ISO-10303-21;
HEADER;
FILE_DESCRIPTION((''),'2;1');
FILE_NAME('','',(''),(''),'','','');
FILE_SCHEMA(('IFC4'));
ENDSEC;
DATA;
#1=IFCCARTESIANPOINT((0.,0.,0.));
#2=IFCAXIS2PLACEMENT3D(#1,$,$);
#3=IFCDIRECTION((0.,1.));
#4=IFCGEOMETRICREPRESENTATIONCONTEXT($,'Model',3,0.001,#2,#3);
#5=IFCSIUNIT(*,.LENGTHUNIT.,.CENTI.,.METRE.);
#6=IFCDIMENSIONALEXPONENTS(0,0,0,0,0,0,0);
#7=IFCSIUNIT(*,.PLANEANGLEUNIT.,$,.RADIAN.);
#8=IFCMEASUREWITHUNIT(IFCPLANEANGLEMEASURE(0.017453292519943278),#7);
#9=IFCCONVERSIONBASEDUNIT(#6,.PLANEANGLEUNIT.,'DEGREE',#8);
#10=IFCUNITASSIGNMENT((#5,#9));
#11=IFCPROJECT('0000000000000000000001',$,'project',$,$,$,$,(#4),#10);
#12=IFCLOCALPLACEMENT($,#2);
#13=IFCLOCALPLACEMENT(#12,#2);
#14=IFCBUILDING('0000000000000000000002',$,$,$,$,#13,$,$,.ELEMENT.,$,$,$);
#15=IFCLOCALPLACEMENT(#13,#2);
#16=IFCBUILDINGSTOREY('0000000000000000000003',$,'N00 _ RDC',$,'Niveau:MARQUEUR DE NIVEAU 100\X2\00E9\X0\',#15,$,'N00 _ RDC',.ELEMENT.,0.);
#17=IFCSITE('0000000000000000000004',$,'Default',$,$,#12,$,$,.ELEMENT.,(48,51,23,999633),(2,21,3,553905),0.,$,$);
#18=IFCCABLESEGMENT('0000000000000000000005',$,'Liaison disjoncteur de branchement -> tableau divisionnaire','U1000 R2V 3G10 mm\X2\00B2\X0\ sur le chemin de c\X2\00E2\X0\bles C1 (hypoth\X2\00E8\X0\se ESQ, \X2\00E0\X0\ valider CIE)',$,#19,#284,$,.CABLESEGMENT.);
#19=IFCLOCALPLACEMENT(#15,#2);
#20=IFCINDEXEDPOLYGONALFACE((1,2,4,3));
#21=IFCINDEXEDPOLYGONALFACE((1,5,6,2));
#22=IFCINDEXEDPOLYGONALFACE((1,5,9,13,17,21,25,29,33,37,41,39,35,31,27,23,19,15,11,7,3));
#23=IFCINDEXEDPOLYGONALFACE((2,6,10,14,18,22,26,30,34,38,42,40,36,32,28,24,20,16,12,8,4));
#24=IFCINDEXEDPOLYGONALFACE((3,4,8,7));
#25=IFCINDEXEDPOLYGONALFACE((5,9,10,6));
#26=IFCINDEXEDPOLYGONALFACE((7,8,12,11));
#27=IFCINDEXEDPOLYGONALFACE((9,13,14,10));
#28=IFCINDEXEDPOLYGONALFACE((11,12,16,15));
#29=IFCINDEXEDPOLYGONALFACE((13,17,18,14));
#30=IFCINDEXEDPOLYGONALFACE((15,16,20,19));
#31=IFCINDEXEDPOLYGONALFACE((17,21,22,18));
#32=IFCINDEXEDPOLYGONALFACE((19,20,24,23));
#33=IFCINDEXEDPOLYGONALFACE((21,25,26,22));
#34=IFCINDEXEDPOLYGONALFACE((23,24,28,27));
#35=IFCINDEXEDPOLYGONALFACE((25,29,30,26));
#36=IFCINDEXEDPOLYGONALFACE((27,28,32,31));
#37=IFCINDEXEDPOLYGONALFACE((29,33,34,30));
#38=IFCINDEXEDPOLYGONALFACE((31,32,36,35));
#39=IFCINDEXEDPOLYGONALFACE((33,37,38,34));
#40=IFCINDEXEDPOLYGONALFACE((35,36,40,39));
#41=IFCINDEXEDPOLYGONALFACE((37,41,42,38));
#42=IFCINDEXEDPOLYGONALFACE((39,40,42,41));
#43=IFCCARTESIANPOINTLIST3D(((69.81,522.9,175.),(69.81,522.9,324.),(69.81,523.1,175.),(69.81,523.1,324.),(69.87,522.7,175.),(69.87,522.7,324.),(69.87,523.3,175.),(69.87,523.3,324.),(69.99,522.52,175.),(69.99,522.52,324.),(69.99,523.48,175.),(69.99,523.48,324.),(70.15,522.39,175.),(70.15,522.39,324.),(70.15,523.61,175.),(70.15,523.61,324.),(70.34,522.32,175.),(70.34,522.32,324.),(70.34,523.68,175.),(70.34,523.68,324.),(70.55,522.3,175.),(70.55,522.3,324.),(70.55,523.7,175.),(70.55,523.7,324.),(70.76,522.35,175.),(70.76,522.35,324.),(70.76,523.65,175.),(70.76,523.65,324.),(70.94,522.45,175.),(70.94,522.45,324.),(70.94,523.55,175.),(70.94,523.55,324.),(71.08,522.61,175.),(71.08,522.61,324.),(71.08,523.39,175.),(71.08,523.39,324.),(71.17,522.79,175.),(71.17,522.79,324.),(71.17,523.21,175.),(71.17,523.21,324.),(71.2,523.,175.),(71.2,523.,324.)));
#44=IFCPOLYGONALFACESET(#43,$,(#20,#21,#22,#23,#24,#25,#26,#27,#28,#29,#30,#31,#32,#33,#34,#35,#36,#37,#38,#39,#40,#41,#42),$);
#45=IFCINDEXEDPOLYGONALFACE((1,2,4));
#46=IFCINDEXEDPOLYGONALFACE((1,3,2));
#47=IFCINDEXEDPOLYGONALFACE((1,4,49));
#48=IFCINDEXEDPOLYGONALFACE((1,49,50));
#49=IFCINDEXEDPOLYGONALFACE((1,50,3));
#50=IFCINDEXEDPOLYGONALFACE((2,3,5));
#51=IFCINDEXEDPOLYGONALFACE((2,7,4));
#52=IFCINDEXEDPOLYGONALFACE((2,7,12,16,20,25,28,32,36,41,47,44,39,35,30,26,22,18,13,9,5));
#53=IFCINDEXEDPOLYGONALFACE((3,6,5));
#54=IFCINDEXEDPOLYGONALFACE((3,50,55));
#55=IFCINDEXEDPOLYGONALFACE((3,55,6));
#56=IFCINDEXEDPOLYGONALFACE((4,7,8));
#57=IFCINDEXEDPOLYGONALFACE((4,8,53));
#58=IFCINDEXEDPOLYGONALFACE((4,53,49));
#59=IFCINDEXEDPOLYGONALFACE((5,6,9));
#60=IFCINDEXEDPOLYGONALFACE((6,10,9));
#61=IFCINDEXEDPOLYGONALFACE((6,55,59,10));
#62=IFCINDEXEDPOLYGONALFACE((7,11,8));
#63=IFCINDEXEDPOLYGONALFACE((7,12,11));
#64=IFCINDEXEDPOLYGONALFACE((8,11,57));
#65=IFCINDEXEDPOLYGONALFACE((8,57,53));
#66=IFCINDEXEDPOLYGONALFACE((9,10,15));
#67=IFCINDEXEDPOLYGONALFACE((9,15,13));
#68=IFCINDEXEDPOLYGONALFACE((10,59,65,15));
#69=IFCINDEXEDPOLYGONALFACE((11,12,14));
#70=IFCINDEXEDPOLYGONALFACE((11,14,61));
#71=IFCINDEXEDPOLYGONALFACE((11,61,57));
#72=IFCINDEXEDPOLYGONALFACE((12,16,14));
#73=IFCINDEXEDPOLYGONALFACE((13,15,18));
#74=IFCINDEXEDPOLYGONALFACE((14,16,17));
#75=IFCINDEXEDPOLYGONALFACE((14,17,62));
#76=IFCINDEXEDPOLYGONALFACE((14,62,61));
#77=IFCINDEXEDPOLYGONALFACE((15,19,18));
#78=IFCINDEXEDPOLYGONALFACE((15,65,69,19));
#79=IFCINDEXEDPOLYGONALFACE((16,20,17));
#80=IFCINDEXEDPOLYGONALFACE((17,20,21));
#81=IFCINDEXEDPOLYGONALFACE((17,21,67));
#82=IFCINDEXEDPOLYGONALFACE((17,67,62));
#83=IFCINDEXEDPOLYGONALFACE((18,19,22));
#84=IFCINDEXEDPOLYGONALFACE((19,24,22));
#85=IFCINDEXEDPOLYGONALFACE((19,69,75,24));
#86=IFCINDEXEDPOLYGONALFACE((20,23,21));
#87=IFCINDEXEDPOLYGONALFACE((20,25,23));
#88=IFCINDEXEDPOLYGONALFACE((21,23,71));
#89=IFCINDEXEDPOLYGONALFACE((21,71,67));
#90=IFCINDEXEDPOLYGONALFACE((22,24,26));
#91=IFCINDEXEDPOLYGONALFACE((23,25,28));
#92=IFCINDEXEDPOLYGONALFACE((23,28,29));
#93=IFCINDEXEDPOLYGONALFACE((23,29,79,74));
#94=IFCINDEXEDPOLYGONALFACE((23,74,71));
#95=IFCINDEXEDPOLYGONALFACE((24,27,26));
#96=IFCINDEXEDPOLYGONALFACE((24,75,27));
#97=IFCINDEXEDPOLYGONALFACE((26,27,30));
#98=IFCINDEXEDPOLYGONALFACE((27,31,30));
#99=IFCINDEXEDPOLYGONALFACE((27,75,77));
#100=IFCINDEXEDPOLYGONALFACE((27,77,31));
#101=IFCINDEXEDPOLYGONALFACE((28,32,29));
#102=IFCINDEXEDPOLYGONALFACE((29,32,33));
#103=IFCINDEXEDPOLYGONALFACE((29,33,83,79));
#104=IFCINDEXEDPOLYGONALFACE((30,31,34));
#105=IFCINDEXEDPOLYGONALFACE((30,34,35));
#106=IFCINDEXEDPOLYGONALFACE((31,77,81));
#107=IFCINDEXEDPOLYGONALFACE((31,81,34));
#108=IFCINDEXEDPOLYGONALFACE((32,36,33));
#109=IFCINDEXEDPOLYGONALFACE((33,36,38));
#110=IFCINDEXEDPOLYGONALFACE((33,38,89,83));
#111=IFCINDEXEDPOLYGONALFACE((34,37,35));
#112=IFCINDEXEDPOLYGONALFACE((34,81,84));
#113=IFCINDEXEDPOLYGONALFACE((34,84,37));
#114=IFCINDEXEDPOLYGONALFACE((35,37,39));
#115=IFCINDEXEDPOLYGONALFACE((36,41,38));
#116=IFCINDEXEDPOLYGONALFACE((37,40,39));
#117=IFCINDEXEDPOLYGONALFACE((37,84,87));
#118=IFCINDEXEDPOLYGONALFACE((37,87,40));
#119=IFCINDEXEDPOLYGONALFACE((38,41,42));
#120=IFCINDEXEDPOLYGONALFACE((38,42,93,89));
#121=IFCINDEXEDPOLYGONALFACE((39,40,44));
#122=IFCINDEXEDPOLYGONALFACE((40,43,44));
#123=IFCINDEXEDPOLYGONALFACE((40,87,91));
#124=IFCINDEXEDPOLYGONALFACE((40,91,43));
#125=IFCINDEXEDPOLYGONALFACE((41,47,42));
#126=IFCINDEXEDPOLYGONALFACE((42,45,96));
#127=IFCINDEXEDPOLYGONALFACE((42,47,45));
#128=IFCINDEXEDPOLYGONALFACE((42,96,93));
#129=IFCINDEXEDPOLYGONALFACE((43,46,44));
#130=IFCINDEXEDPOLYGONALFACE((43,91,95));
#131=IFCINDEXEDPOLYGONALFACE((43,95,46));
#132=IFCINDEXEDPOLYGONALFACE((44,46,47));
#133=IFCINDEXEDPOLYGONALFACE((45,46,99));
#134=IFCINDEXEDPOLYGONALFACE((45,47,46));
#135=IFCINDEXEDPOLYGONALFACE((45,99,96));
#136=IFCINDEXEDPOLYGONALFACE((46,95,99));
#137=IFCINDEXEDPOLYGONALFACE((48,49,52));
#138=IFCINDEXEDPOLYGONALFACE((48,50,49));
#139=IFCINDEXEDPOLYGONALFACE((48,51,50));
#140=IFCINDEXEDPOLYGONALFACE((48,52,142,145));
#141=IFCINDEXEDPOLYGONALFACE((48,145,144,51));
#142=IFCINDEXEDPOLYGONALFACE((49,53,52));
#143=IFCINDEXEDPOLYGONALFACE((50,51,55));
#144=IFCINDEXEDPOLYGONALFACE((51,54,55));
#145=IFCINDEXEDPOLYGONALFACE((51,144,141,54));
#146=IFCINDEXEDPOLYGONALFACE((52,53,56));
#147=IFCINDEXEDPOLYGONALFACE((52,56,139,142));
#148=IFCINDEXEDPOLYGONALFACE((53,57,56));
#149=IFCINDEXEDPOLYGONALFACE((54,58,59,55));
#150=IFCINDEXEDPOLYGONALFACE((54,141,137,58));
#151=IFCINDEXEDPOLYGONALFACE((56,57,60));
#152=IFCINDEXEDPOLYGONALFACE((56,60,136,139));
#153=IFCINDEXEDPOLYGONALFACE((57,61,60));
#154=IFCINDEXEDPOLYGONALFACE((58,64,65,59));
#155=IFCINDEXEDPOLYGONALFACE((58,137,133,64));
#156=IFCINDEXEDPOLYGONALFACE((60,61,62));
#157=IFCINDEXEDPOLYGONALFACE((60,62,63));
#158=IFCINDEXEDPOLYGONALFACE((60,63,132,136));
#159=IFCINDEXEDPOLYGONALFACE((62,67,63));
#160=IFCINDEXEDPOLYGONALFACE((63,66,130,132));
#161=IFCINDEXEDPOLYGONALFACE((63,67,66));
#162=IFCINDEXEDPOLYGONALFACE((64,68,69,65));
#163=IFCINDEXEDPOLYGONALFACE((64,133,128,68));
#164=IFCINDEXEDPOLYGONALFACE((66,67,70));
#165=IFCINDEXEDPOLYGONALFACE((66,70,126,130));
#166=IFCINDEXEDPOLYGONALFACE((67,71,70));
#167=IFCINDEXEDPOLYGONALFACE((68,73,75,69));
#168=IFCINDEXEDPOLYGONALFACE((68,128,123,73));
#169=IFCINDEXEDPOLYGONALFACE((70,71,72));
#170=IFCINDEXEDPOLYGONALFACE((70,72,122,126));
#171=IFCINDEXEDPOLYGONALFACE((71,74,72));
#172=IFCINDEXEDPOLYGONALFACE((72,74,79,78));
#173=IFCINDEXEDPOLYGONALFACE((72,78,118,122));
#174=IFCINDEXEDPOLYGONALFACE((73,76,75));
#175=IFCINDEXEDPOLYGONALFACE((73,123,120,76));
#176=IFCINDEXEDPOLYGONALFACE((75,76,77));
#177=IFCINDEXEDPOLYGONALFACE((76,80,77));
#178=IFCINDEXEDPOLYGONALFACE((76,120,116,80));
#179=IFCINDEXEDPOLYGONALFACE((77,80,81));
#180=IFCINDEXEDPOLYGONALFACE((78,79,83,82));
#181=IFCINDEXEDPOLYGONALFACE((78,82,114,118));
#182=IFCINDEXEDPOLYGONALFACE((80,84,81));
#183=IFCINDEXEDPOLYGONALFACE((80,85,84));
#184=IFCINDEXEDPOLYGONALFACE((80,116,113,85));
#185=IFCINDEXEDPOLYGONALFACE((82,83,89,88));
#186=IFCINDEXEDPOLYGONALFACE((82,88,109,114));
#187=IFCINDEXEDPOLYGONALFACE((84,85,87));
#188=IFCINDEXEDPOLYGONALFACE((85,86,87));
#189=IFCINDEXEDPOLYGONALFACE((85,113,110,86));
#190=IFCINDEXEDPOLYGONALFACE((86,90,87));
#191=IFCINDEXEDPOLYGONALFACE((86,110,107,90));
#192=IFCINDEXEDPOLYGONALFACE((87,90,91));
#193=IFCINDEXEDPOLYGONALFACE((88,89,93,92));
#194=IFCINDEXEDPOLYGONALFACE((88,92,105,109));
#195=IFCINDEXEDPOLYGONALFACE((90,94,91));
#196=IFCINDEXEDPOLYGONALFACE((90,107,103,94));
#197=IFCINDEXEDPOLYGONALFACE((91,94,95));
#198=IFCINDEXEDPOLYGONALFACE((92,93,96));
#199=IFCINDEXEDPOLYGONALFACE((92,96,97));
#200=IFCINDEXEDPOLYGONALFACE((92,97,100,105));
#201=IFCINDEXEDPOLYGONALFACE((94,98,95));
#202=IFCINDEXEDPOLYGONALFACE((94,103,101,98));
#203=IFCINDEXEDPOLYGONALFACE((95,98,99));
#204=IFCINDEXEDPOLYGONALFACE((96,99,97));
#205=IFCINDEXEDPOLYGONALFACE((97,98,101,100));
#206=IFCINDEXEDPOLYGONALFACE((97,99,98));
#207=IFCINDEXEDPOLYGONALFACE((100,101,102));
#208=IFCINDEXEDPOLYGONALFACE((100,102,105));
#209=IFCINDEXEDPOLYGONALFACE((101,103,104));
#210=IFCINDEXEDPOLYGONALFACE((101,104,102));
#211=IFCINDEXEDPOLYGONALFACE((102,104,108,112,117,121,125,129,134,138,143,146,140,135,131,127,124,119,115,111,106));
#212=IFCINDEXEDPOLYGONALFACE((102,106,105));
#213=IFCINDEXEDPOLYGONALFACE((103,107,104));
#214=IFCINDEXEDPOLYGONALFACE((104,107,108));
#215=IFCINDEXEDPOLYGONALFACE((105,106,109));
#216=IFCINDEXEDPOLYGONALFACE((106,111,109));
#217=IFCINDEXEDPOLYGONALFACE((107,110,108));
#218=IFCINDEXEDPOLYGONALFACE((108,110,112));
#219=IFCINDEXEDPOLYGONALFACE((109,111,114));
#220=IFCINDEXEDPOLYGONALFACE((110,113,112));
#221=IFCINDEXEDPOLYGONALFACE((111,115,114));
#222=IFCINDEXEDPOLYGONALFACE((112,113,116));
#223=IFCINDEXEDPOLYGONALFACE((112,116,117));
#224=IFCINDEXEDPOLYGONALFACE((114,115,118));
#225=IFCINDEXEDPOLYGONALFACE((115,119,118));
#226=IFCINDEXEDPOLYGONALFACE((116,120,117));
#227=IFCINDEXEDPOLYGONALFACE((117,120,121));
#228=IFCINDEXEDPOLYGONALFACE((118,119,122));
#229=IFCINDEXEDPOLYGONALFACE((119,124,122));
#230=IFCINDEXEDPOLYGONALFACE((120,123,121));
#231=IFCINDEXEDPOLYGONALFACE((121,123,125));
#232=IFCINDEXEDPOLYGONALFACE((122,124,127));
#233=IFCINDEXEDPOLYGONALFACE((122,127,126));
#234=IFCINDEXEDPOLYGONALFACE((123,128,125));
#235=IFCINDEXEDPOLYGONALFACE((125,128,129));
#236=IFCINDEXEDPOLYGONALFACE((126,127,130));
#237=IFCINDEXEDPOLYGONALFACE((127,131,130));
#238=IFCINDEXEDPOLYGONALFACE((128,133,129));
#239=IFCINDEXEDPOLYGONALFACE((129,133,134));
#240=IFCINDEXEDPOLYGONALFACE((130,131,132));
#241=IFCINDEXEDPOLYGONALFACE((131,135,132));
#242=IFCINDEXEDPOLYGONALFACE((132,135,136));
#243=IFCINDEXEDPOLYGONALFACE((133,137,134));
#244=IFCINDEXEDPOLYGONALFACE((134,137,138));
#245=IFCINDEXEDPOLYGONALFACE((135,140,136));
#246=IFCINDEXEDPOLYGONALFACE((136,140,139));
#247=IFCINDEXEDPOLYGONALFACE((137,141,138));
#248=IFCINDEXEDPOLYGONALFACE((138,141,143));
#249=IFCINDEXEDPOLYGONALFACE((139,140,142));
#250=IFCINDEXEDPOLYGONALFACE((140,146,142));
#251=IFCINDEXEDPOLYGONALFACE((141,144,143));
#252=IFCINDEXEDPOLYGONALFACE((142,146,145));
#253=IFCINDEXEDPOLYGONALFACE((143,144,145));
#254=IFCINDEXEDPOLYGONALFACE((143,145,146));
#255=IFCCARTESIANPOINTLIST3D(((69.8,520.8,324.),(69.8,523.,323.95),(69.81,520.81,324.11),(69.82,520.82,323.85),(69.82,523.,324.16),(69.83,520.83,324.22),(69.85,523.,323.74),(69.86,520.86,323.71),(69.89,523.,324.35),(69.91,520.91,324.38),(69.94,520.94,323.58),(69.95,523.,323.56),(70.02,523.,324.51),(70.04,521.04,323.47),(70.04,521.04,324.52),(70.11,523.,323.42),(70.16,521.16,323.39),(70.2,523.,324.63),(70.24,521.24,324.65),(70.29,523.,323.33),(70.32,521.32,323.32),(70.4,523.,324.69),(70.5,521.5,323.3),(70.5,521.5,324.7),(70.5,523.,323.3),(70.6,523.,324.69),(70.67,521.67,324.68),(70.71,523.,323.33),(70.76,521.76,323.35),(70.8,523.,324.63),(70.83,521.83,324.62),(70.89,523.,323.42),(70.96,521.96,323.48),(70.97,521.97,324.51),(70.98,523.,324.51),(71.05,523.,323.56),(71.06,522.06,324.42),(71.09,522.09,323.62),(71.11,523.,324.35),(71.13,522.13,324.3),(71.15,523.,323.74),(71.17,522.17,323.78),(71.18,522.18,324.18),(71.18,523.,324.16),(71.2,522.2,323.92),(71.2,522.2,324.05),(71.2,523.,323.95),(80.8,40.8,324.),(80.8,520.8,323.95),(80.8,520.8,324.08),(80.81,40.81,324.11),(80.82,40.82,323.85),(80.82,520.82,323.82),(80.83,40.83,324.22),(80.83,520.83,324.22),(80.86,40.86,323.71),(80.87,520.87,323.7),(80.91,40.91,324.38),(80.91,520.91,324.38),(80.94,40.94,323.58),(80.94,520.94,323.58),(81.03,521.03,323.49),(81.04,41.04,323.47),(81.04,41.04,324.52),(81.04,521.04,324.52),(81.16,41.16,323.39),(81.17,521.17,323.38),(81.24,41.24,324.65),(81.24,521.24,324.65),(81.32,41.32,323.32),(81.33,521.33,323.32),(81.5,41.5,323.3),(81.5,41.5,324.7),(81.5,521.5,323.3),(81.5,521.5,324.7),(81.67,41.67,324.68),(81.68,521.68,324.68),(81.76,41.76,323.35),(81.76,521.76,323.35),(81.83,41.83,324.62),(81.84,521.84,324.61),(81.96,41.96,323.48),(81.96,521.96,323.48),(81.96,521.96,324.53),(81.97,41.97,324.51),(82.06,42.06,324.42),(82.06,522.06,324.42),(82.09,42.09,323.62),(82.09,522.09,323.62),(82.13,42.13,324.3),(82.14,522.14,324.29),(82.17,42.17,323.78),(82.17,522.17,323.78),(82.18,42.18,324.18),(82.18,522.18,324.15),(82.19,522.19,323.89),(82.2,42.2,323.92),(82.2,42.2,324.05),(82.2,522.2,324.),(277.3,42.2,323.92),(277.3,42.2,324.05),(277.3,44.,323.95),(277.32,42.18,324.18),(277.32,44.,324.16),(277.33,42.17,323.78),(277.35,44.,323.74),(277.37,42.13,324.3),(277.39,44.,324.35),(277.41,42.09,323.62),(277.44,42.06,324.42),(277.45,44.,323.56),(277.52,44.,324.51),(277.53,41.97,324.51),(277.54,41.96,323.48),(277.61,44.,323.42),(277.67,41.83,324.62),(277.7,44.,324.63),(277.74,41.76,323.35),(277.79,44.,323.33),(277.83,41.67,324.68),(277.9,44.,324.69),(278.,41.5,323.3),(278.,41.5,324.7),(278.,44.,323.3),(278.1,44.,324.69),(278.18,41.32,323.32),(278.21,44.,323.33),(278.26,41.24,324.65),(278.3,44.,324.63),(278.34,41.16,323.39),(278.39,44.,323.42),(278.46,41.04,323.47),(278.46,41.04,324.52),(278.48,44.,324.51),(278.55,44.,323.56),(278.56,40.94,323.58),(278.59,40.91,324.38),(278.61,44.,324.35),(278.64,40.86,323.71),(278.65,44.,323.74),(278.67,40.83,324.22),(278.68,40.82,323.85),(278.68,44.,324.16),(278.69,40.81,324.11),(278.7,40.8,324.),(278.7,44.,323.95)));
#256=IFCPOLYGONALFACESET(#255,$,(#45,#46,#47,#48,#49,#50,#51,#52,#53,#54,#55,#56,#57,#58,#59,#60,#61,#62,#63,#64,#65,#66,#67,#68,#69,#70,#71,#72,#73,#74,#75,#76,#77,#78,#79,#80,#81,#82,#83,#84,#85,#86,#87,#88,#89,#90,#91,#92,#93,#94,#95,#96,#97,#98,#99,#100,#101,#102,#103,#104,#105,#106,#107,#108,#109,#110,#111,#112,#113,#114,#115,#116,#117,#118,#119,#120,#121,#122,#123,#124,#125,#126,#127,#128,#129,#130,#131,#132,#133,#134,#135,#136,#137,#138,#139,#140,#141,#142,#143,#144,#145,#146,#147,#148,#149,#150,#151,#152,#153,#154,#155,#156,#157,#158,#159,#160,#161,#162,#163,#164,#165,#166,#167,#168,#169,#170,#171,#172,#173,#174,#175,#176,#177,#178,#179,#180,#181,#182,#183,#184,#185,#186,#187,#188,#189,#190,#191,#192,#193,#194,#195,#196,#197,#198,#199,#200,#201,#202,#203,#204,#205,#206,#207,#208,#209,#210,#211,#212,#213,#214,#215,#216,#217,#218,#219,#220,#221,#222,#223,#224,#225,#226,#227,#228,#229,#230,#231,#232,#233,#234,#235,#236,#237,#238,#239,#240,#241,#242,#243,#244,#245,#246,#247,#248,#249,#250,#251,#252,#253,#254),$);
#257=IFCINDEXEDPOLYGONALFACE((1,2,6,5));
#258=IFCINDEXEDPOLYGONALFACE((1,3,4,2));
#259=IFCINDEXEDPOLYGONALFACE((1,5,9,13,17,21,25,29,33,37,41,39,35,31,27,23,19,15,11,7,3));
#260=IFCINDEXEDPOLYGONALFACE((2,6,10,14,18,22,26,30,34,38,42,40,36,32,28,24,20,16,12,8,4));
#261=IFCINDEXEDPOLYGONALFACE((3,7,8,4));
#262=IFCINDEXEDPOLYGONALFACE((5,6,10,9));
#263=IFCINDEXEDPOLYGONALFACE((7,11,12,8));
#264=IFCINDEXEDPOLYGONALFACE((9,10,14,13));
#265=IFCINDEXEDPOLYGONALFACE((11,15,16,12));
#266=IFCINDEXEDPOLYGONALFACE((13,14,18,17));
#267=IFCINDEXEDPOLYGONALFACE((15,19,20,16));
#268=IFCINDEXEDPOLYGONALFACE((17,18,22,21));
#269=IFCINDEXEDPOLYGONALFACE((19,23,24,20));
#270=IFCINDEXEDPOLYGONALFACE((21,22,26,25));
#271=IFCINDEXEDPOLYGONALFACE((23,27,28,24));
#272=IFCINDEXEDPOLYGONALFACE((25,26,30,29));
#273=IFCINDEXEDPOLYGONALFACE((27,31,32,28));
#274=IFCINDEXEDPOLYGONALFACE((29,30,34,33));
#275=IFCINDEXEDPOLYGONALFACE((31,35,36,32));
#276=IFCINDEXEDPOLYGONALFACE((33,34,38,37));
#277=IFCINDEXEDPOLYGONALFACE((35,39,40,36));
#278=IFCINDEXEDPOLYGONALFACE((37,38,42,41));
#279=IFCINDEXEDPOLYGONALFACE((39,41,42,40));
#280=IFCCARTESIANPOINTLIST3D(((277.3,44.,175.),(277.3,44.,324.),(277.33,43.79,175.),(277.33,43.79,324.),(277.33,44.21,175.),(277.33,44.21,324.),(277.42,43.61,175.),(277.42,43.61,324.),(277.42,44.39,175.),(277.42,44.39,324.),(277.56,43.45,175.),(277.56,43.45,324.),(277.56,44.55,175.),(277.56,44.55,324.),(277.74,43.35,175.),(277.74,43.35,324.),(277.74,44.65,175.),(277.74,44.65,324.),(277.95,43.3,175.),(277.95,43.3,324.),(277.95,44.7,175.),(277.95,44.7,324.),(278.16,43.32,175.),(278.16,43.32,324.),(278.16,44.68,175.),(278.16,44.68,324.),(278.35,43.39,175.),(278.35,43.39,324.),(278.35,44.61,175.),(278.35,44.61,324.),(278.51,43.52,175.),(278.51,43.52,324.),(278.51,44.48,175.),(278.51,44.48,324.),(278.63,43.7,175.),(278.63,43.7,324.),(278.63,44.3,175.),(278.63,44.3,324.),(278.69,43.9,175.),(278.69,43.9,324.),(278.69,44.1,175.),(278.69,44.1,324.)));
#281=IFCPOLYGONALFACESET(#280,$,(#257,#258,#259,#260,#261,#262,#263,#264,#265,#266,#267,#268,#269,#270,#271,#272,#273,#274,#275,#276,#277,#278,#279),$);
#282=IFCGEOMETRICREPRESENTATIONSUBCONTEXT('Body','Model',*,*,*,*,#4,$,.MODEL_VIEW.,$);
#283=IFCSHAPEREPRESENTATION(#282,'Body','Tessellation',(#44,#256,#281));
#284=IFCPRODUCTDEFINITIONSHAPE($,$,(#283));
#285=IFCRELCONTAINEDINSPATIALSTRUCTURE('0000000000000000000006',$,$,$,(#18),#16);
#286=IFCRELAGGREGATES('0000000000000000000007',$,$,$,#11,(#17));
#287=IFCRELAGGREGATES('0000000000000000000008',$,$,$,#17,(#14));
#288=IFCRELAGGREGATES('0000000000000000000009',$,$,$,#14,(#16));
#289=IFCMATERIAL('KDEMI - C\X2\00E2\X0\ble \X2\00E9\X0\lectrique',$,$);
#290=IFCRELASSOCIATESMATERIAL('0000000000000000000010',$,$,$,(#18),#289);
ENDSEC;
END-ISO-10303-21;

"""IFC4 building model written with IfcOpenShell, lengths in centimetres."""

from ifc_helpers import new_model, entity, si_unit, converted_unit, direction, origin, origin_with_axes, place, context, subcontext, project, spatial, material, element, save


model = new_model("IFC4")

# Units and contexts
model_context = context("Model", 3, precision=0.001, world=origin(), true_north=direction((0.0, 1.0)))
body_context = subcontext(model_context, "Body", "Model", "MODEL_VIEW")
ifc_project = project(units=[si_unit("LENGTHUNIT", "METRE", prefix="CENTI"), converted_unit("PLANEANGLEUNIT", "DEGREE", entity("IfcPlaneAngleMeasure", 0.017453292519943278), si_unit("PLANEANGLEUNIT", "RADIAN"), dimensions=[0, 0, 0, 0, 0, 0, 0])], contexts=[model_context])

# Site, building, storey
site_placement = place(None, origin())
site = spatial("IfcSite", under=ifc_project, at=site_placement, Name="Default", CompositionType="ELEMENT", RefLatitude=(48, 51, 23, 999633), RefLongitude=(2, 21, 3, 553905), RefElevation=0.0)
building_placement = place(site_placement, origin())
building = spatial("IfcBuilding", under=site, at=building_placement, CompositionType="ELEMENT")
storey_placement = place(building_placement, origin())
storey = spatial("IfcBuildingStorey", under=building, at=storey_placement, Name="N00 _ RDC", ObjectType="Niveau:MARQUEUR DE NIVEAU 100é", LongName="N00 _ RDC", CompositionType="ELEMENT", Elevation=0.0)

# Cable segment
ifc_material_1 = material(Name="KDEMI - Câble électrique")
cable_segment_1_placement = place(storey_placement, origin_with_axes())
element("IfcCableSegment", 1, at=cable_segment_1_placement, inside=storey, material=ifc_material_1, Name="Liaison disjoncteur de branchement -> tableau divisionnaire", Description="U1000 R2V 3G10 mm² sur le chemin de câbles C1 (hypothèse ESQ, à valider CIE)", PredefinedType="CABLESEGMENT", context=body_context, shape_type="AdvancedSweptSolid", body=[
    entity("IfcSweptDiskSolid", entity("IfcPolyline", [entity("IfcCartesianPoint", [70.5, 523.0, 175.0]), entity("IfcCartesianPoint", [70.5, 523.0, 324.0])]), 0.7),
    entity("IfcSweptDiskSolid", entity("IfcPolyline", [entity("IfcCartesianPoint", [70.5, 523.0, 324.0]), entity("IfcCartesianPoint", [70.5, 521.5, 324.0]), entity("IfcCartesianPoint", [81.5, 521.5, 324.0]), entity("IfcCartesianPoint", [81.5, 41.5, 324.0]), entity("IfcCartesianPoint", [278.0, 41.5, 324.0]), entity("IfcCartesianPoint", [278.0, 44.0, 324.0])]), 0.7),
    entity("IfcSweptDiskSolid", entity("IfcPolyline", [entity("IfcCartesianPoint", [278.0, 44.0, 324.0]), entity("IfcCartesianPoint", [278.0, 44.0, 175.0])]), 0.7),
])

save(model, "model.ifc")
